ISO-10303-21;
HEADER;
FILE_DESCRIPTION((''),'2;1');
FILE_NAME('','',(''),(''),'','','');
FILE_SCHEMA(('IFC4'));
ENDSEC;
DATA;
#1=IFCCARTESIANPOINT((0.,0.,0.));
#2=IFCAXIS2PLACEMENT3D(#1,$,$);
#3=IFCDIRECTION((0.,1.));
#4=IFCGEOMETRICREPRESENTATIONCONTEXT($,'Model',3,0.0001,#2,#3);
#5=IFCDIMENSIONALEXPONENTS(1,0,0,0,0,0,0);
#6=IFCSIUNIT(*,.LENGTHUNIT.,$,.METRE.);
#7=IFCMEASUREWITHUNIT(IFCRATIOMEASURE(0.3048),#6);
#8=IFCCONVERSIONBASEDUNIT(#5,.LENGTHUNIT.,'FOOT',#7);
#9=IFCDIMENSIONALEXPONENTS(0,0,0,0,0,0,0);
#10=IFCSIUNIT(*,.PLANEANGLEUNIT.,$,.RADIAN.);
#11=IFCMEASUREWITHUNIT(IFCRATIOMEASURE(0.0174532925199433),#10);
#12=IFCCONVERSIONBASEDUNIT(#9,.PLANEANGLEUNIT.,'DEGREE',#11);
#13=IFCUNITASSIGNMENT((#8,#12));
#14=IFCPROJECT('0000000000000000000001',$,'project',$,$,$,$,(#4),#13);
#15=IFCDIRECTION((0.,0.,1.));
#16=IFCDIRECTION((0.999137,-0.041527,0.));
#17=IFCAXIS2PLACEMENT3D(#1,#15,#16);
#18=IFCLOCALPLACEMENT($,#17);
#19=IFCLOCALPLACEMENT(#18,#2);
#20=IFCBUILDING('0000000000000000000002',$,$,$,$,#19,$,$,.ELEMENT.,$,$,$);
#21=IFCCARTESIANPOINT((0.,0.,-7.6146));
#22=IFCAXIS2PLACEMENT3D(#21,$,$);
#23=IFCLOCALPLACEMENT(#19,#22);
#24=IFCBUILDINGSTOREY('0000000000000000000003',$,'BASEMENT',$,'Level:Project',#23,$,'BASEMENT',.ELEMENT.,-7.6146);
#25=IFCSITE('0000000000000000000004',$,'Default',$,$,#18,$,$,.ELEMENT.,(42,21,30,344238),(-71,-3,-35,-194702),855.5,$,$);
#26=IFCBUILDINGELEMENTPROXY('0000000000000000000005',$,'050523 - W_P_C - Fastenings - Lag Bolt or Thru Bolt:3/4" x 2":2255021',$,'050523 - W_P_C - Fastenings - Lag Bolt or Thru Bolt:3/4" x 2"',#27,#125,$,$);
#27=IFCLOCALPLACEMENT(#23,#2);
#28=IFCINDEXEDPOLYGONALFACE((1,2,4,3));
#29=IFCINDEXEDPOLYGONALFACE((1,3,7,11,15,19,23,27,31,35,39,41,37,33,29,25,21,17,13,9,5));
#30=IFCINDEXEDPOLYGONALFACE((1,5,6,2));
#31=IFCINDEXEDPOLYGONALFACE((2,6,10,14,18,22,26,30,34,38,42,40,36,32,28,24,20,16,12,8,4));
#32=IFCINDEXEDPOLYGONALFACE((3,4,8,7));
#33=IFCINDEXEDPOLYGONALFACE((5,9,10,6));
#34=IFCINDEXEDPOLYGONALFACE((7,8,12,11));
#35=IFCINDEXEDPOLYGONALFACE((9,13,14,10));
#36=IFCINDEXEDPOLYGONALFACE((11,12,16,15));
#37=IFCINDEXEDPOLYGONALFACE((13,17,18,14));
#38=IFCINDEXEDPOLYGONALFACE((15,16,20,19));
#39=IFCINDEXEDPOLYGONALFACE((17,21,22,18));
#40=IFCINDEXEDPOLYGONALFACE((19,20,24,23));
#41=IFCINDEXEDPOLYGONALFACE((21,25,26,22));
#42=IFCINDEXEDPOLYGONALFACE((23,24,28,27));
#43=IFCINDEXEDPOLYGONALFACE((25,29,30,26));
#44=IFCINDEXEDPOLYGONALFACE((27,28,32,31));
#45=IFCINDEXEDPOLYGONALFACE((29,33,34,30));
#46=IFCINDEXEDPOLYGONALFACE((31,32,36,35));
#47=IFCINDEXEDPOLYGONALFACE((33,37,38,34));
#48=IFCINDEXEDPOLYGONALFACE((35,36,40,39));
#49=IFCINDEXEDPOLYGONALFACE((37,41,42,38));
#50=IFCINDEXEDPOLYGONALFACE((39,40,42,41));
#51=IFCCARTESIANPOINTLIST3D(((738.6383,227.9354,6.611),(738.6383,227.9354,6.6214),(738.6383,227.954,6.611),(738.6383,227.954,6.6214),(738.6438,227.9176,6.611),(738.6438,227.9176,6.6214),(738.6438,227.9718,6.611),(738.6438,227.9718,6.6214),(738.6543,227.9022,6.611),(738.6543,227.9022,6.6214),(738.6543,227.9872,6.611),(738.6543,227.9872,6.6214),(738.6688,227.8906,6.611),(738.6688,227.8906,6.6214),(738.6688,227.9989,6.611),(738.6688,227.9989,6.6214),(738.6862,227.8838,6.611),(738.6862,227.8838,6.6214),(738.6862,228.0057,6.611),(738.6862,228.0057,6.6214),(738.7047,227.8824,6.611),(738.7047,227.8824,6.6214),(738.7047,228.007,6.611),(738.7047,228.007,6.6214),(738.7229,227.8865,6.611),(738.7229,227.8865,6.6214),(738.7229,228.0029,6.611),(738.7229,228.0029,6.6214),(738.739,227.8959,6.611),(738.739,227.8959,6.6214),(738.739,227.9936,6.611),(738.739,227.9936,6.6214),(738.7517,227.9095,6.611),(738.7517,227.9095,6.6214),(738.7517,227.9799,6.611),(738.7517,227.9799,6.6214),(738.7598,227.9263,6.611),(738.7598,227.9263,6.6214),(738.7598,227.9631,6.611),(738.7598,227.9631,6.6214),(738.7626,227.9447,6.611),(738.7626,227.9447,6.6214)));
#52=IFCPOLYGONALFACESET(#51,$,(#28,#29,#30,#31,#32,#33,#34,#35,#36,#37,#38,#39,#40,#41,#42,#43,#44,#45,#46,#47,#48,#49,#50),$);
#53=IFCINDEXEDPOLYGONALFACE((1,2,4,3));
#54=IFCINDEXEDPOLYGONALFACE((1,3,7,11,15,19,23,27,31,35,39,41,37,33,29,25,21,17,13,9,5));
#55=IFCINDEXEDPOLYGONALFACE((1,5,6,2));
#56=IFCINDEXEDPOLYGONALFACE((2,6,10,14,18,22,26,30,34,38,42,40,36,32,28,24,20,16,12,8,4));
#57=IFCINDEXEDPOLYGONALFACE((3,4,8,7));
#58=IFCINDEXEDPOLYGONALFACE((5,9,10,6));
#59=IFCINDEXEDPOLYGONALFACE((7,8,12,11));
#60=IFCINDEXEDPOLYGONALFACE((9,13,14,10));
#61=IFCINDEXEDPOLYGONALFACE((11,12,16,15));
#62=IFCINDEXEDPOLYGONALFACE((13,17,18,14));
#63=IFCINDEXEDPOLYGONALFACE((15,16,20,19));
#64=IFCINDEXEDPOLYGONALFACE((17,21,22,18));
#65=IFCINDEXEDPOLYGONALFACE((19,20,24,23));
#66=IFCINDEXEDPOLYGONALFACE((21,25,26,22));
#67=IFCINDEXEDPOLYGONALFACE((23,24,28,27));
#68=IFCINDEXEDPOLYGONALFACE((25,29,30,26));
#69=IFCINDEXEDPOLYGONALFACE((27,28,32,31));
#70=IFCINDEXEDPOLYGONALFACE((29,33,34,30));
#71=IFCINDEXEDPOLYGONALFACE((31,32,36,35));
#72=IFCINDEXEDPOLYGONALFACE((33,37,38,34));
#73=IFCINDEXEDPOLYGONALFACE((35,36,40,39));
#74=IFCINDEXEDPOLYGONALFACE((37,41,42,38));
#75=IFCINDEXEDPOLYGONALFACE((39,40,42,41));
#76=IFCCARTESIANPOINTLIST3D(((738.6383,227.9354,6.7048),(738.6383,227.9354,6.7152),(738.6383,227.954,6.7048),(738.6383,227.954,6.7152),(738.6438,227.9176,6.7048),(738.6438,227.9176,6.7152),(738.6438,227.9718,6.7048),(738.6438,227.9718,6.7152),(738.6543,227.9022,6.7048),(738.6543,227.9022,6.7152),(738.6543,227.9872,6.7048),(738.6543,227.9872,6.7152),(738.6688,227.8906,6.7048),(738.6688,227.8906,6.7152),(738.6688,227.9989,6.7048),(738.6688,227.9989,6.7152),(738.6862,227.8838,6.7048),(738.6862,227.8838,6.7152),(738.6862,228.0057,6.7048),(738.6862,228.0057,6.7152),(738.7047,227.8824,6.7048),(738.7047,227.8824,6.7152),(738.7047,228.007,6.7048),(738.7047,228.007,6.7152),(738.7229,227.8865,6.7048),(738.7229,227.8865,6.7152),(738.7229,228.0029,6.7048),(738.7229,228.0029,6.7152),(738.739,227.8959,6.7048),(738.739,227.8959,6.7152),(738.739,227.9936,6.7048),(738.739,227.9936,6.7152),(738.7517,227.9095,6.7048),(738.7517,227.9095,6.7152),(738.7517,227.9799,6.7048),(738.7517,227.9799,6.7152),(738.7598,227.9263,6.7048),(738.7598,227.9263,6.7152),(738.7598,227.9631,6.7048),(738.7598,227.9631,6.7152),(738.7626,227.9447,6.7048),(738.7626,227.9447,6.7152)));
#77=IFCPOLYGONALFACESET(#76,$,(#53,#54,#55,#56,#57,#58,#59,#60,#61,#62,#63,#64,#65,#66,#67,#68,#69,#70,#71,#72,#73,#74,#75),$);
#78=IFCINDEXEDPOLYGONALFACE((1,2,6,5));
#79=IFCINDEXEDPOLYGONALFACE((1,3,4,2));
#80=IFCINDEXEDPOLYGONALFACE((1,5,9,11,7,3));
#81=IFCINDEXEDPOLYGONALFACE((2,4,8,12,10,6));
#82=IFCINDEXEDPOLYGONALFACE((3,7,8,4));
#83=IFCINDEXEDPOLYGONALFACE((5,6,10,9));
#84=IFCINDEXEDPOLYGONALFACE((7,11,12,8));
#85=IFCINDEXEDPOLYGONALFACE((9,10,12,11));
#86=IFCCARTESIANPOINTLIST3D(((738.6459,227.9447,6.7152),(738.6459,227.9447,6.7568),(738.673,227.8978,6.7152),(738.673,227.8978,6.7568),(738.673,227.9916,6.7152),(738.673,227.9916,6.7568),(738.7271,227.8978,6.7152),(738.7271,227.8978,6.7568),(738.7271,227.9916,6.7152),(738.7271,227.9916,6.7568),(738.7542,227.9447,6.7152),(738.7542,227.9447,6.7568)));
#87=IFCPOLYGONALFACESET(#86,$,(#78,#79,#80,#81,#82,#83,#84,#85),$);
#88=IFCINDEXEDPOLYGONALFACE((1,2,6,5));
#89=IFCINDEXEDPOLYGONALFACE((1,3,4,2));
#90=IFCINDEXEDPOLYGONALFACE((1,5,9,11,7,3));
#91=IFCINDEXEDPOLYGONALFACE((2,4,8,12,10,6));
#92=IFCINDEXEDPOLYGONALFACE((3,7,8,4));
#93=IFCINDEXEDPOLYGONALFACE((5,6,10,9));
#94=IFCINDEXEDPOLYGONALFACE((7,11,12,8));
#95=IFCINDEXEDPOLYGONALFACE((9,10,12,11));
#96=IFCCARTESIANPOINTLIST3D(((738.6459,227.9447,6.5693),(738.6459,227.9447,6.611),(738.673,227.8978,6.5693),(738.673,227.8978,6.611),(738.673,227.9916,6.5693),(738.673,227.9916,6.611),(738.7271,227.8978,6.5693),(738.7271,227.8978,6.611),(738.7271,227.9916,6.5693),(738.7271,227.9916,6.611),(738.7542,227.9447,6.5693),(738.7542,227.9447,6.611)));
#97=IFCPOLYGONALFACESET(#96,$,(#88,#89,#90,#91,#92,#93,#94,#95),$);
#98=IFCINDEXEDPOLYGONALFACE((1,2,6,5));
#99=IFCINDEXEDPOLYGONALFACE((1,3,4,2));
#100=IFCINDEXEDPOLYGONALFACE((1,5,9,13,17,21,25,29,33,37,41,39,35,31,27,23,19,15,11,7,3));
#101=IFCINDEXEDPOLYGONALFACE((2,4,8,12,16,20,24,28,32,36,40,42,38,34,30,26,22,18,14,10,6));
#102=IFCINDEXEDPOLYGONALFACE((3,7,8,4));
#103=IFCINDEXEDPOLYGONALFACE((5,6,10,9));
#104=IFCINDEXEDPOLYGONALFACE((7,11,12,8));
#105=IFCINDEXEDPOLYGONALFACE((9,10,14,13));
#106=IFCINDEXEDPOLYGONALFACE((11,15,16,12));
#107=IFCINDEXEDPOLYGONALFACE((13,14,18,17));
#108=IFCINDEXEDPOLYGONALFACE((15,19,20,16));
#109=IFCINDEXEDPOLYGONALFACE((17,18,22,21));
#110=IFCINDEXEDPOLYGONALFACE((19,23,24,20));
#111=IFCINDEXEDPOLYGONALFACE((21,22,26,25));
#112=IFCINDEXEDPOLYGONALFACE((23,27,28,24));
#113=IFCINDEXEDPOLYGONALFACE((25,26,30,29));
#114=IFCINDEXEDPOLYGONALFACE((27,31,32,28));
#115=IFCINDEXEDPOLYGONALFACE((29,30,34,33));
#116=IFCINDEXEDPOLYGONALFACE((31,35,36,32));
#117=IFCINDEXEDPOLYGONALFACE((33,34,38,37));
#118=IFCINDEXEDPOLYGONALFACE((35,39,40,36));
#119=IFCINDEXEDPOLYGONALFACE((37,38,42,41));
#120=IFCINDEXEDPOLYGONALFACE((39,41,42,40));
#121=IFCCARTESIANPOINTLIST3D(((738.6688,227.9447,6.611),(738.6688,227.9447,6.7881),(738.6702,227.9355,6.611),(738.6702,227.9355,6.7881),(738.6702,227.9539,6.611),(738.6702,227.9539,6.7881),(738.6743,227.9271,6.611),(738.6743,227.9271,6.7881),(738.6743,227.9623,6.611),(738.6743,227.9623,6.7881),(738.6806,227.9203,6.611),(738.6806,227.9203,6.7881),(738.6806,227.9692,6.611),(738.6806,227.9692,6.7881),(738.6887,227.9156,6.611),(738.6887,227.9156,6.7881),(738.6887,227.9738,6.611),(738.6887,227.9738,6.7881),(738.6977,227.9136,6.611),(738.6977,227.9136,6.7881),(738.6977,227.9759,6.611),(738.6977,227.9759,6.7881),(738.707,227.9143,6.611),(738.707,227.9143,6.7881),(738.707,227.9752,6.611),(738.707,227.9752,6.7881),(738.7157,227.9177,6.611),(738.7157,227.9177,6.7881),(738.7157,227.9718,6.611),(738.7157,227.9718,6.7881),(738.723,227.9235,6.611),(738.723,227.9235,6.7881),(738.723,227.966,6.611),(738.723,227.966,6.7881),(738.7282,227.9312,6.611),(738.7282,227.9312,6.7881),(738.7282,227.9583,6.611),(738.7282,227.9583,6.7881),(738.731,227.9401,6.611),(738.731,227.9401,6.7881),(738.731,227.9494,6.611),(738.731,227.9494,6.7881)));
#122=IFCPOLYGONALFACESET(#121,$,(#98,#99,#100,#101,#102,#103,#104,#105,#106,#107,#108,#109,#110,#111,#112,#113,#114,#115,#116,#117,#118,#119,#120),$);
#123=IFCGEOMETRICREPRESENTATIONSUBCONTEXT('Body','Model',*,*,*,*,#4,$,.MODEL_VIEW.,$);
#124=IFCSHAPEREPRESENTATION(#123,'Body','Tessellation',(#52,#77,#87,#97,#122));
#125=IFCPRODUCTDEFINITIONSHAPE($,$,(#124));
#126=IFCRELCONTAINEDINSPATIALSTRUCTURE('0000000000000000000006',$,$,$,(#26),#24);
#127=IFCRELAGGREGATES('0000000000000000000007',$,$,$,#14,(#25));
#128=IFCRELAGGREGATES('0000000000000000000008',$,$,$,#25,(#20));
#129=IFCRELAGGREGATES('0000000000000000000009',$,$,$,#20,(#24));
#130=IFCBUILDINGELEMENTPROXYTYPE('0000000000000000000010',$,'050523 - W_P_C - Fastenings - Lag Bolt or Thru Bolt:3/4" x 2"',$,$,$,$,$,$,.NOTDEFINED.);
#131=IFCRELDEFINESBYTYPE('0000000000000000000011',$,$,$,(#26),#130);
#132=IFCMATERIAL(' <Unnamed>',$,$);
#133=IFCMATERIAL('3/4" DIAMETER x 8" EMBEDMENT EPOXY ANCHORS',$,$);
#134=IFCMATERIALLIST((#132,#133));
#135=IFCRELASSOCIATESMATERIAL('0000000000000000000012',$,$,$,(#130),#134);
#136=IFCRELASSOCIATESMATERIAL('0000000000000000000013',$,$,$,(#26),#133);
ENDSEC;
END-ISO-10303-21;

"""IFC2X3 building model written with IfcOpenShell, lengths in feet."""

from ifc_helpers import new_model, entity, si_unit, converted_unit, direction, frame, frame_2d, origin, place, context, subcontext, project, spatial, polyline, circle, outline, extrude, source, transform, mapped, material, material_list, type_object, type_shapes, element, save


model = new_model("IFC2X3")

# Units and contexts
model_context = context("Model", 3, precision=0.0001, world=origin(), true_north=direction((0.0, 1.0)))
body_context = subcontext(model_context, "Body", "Model", "MODEL_VIEW")
ifc_project = project(units=[converted_unit("LENGTHUNIT", "FOOT", entity("IfcRatioMeasure", 0.3048), si_unit("LENGTHUNIT", "METRE"), dimensions=[1, 0, 0, 0, 0, 0, 0]), converted_unit("PLANEANGLEUNIT", "DEGREE", entity("IfcRatioMeasure", 0.0174532925199433), si_unit("PLANEANGLEUNIT", "RADIAN"), dimensions=[0, 0, 0, 0, 0, 0, 0])], contexts=[model_context])

# Site, building, storey
site_placement = place(None, frame((0.0, 0.0, 0.0), z_axis=(0.0, 0.0, 1.0), x_axis=(0.999137, -0.041527, 0.0)))
site = spatial("IfcSite", under=ifc_project, at=site_placement, Name="Default", CompositionType="ELEMENT", RefLatitude=(42, 21, 30, 344238), RefLongitude=(-71, -3, -35, -194702), RefElevation=855.5)
building_placement = place(site_placement, origin())
building = spatial("IfcBuilding", under=site, at=building_placement, CompositionType="ELEMENT")
storey_placement = place(building_placement, frame((0.0, 0.0, -7.6146)))
storey = spatial("IfcBuildingStorey", under=building, at=storey_placement, Name="BASEMENT", ObjectType="Level:Project", LongName="BASEMENT", CompositionType="ELEMENT", Elevation=-7.6146)

# Building element proxy
ifc_material_1 = material(Name=" <Unnamed>")
ifc_material_2 = material(Name="3/4\" DIAMETER x 8\" EMBEDMENT EPOXY ANCHORS")
ifc_material_list_1 = material_list([ifc_material_1, ifc_material_2])
building_element_proxy_type_1 = type_object("IfcBuildingElementProxyType", Name="050523 - W_P_C - Fastenings - Lag Bolt or Thru Bolt:3/4\" x 2\"", PredefinedType="NOTDEFINED", material=ifc_material_list_1)
shared_shape_1 = source(origin(), body_context, "Body", "SweptSolid", [
    extrude(circle(Radius=0.0625, at=frame_2d((0.0, 0.0), x_axis=(1.0, 0.0))), frame((0.0, 0.0, 0.0), z_axis=(0.0, 0.0, 1.0), x_axis=(0.0, -1.0, 0.0)), (0.0, 0.0, 1.0), 0.0104),
    extrude(circle(Radius=0.0625, at=frame_2d((0.0, 0.0), x_axis=(1.0, 0.0))), frame((0.0, 0.0, -0.0938), z_axis=(0.0, 0.0, 1.0), x_axis=(0.0, -1.0, 0.0)), (0.0, 0.0, 1.0), 0.0104),
    extrude(outline(polyline([(-0.0271, -0.0469), (0.0271, -0.0469), (0.0541, 0.0), (0.0271, 0.0469), (-0.0271, 0.0469), (-0.0541, 0.0), (-0.0271, -0.0469)])), frame((0.0, 0.0, -0.1354), z_axis=(0.0, 0.0, 1.0), x_axis=(0.866025, -0.5, 0.0)), (0.0, 0.0, 1.0), 0.0417),
    extrude(outline(polyline([(-0.0271, -0.0469), (0.0271, -0.0469), (0.0541, 0.0), (0.0271, 0.0469), (-0.0271, 0.0469), (-0.0541, 0.0), (-0.0271, -0.0469)])), frame((0.0, 0.0, 0.0104), z_axis=(0.0, 0.0, 1.0), x_axis=(0.0, -1.0, 0.0)), (0.0, 0.0, 1.0), 0.0417),
    extrude(circle(Radius=0.0312, at=frame_2d((0.0, 0.0), x_axis=(1.0, 0.0))), frame((0.0, 0.0, -0.1667), z_axis=(0.0, 0.0, 1.0), x_axis=(0.0, 1.0, 0.0)), (0.0, 0.0, 1.0), 0.1771),
])
type_shapes(building_element_proxy_type_1, [shared_shape_1])
for number, where, z_axis, x_axis, name in (
    (1, (738.7001, 227.9447, 6.6214), (0.0, 0.0, -1.0), (0.0, -1.0, 0.0), "050523 - W_P_C - Fastenings - Lag Bolt or Thru Bolt:3/4\" x 2\":2255021"),
):
    element("IfcBuildingElementProxy", number, at=place(storey_placement, frame(where, z_axis=z_axis, x_axis=x_axis)), inside=storey, type_object=building_element_proxy_type_1, material=ifc_material_2, Name=name, ObjectType="050523 - W_P_C - Fastenings - Lag Bolt or Thru Bolt:3/4\" x 2\"", context=body_context, shape_type="MappedRepresentation", body=[
        mapped(shared_shape_1, transform((0.0, 0.0, 0.0), scale=1.0)),
    ])

save(model, "model.ifc")
